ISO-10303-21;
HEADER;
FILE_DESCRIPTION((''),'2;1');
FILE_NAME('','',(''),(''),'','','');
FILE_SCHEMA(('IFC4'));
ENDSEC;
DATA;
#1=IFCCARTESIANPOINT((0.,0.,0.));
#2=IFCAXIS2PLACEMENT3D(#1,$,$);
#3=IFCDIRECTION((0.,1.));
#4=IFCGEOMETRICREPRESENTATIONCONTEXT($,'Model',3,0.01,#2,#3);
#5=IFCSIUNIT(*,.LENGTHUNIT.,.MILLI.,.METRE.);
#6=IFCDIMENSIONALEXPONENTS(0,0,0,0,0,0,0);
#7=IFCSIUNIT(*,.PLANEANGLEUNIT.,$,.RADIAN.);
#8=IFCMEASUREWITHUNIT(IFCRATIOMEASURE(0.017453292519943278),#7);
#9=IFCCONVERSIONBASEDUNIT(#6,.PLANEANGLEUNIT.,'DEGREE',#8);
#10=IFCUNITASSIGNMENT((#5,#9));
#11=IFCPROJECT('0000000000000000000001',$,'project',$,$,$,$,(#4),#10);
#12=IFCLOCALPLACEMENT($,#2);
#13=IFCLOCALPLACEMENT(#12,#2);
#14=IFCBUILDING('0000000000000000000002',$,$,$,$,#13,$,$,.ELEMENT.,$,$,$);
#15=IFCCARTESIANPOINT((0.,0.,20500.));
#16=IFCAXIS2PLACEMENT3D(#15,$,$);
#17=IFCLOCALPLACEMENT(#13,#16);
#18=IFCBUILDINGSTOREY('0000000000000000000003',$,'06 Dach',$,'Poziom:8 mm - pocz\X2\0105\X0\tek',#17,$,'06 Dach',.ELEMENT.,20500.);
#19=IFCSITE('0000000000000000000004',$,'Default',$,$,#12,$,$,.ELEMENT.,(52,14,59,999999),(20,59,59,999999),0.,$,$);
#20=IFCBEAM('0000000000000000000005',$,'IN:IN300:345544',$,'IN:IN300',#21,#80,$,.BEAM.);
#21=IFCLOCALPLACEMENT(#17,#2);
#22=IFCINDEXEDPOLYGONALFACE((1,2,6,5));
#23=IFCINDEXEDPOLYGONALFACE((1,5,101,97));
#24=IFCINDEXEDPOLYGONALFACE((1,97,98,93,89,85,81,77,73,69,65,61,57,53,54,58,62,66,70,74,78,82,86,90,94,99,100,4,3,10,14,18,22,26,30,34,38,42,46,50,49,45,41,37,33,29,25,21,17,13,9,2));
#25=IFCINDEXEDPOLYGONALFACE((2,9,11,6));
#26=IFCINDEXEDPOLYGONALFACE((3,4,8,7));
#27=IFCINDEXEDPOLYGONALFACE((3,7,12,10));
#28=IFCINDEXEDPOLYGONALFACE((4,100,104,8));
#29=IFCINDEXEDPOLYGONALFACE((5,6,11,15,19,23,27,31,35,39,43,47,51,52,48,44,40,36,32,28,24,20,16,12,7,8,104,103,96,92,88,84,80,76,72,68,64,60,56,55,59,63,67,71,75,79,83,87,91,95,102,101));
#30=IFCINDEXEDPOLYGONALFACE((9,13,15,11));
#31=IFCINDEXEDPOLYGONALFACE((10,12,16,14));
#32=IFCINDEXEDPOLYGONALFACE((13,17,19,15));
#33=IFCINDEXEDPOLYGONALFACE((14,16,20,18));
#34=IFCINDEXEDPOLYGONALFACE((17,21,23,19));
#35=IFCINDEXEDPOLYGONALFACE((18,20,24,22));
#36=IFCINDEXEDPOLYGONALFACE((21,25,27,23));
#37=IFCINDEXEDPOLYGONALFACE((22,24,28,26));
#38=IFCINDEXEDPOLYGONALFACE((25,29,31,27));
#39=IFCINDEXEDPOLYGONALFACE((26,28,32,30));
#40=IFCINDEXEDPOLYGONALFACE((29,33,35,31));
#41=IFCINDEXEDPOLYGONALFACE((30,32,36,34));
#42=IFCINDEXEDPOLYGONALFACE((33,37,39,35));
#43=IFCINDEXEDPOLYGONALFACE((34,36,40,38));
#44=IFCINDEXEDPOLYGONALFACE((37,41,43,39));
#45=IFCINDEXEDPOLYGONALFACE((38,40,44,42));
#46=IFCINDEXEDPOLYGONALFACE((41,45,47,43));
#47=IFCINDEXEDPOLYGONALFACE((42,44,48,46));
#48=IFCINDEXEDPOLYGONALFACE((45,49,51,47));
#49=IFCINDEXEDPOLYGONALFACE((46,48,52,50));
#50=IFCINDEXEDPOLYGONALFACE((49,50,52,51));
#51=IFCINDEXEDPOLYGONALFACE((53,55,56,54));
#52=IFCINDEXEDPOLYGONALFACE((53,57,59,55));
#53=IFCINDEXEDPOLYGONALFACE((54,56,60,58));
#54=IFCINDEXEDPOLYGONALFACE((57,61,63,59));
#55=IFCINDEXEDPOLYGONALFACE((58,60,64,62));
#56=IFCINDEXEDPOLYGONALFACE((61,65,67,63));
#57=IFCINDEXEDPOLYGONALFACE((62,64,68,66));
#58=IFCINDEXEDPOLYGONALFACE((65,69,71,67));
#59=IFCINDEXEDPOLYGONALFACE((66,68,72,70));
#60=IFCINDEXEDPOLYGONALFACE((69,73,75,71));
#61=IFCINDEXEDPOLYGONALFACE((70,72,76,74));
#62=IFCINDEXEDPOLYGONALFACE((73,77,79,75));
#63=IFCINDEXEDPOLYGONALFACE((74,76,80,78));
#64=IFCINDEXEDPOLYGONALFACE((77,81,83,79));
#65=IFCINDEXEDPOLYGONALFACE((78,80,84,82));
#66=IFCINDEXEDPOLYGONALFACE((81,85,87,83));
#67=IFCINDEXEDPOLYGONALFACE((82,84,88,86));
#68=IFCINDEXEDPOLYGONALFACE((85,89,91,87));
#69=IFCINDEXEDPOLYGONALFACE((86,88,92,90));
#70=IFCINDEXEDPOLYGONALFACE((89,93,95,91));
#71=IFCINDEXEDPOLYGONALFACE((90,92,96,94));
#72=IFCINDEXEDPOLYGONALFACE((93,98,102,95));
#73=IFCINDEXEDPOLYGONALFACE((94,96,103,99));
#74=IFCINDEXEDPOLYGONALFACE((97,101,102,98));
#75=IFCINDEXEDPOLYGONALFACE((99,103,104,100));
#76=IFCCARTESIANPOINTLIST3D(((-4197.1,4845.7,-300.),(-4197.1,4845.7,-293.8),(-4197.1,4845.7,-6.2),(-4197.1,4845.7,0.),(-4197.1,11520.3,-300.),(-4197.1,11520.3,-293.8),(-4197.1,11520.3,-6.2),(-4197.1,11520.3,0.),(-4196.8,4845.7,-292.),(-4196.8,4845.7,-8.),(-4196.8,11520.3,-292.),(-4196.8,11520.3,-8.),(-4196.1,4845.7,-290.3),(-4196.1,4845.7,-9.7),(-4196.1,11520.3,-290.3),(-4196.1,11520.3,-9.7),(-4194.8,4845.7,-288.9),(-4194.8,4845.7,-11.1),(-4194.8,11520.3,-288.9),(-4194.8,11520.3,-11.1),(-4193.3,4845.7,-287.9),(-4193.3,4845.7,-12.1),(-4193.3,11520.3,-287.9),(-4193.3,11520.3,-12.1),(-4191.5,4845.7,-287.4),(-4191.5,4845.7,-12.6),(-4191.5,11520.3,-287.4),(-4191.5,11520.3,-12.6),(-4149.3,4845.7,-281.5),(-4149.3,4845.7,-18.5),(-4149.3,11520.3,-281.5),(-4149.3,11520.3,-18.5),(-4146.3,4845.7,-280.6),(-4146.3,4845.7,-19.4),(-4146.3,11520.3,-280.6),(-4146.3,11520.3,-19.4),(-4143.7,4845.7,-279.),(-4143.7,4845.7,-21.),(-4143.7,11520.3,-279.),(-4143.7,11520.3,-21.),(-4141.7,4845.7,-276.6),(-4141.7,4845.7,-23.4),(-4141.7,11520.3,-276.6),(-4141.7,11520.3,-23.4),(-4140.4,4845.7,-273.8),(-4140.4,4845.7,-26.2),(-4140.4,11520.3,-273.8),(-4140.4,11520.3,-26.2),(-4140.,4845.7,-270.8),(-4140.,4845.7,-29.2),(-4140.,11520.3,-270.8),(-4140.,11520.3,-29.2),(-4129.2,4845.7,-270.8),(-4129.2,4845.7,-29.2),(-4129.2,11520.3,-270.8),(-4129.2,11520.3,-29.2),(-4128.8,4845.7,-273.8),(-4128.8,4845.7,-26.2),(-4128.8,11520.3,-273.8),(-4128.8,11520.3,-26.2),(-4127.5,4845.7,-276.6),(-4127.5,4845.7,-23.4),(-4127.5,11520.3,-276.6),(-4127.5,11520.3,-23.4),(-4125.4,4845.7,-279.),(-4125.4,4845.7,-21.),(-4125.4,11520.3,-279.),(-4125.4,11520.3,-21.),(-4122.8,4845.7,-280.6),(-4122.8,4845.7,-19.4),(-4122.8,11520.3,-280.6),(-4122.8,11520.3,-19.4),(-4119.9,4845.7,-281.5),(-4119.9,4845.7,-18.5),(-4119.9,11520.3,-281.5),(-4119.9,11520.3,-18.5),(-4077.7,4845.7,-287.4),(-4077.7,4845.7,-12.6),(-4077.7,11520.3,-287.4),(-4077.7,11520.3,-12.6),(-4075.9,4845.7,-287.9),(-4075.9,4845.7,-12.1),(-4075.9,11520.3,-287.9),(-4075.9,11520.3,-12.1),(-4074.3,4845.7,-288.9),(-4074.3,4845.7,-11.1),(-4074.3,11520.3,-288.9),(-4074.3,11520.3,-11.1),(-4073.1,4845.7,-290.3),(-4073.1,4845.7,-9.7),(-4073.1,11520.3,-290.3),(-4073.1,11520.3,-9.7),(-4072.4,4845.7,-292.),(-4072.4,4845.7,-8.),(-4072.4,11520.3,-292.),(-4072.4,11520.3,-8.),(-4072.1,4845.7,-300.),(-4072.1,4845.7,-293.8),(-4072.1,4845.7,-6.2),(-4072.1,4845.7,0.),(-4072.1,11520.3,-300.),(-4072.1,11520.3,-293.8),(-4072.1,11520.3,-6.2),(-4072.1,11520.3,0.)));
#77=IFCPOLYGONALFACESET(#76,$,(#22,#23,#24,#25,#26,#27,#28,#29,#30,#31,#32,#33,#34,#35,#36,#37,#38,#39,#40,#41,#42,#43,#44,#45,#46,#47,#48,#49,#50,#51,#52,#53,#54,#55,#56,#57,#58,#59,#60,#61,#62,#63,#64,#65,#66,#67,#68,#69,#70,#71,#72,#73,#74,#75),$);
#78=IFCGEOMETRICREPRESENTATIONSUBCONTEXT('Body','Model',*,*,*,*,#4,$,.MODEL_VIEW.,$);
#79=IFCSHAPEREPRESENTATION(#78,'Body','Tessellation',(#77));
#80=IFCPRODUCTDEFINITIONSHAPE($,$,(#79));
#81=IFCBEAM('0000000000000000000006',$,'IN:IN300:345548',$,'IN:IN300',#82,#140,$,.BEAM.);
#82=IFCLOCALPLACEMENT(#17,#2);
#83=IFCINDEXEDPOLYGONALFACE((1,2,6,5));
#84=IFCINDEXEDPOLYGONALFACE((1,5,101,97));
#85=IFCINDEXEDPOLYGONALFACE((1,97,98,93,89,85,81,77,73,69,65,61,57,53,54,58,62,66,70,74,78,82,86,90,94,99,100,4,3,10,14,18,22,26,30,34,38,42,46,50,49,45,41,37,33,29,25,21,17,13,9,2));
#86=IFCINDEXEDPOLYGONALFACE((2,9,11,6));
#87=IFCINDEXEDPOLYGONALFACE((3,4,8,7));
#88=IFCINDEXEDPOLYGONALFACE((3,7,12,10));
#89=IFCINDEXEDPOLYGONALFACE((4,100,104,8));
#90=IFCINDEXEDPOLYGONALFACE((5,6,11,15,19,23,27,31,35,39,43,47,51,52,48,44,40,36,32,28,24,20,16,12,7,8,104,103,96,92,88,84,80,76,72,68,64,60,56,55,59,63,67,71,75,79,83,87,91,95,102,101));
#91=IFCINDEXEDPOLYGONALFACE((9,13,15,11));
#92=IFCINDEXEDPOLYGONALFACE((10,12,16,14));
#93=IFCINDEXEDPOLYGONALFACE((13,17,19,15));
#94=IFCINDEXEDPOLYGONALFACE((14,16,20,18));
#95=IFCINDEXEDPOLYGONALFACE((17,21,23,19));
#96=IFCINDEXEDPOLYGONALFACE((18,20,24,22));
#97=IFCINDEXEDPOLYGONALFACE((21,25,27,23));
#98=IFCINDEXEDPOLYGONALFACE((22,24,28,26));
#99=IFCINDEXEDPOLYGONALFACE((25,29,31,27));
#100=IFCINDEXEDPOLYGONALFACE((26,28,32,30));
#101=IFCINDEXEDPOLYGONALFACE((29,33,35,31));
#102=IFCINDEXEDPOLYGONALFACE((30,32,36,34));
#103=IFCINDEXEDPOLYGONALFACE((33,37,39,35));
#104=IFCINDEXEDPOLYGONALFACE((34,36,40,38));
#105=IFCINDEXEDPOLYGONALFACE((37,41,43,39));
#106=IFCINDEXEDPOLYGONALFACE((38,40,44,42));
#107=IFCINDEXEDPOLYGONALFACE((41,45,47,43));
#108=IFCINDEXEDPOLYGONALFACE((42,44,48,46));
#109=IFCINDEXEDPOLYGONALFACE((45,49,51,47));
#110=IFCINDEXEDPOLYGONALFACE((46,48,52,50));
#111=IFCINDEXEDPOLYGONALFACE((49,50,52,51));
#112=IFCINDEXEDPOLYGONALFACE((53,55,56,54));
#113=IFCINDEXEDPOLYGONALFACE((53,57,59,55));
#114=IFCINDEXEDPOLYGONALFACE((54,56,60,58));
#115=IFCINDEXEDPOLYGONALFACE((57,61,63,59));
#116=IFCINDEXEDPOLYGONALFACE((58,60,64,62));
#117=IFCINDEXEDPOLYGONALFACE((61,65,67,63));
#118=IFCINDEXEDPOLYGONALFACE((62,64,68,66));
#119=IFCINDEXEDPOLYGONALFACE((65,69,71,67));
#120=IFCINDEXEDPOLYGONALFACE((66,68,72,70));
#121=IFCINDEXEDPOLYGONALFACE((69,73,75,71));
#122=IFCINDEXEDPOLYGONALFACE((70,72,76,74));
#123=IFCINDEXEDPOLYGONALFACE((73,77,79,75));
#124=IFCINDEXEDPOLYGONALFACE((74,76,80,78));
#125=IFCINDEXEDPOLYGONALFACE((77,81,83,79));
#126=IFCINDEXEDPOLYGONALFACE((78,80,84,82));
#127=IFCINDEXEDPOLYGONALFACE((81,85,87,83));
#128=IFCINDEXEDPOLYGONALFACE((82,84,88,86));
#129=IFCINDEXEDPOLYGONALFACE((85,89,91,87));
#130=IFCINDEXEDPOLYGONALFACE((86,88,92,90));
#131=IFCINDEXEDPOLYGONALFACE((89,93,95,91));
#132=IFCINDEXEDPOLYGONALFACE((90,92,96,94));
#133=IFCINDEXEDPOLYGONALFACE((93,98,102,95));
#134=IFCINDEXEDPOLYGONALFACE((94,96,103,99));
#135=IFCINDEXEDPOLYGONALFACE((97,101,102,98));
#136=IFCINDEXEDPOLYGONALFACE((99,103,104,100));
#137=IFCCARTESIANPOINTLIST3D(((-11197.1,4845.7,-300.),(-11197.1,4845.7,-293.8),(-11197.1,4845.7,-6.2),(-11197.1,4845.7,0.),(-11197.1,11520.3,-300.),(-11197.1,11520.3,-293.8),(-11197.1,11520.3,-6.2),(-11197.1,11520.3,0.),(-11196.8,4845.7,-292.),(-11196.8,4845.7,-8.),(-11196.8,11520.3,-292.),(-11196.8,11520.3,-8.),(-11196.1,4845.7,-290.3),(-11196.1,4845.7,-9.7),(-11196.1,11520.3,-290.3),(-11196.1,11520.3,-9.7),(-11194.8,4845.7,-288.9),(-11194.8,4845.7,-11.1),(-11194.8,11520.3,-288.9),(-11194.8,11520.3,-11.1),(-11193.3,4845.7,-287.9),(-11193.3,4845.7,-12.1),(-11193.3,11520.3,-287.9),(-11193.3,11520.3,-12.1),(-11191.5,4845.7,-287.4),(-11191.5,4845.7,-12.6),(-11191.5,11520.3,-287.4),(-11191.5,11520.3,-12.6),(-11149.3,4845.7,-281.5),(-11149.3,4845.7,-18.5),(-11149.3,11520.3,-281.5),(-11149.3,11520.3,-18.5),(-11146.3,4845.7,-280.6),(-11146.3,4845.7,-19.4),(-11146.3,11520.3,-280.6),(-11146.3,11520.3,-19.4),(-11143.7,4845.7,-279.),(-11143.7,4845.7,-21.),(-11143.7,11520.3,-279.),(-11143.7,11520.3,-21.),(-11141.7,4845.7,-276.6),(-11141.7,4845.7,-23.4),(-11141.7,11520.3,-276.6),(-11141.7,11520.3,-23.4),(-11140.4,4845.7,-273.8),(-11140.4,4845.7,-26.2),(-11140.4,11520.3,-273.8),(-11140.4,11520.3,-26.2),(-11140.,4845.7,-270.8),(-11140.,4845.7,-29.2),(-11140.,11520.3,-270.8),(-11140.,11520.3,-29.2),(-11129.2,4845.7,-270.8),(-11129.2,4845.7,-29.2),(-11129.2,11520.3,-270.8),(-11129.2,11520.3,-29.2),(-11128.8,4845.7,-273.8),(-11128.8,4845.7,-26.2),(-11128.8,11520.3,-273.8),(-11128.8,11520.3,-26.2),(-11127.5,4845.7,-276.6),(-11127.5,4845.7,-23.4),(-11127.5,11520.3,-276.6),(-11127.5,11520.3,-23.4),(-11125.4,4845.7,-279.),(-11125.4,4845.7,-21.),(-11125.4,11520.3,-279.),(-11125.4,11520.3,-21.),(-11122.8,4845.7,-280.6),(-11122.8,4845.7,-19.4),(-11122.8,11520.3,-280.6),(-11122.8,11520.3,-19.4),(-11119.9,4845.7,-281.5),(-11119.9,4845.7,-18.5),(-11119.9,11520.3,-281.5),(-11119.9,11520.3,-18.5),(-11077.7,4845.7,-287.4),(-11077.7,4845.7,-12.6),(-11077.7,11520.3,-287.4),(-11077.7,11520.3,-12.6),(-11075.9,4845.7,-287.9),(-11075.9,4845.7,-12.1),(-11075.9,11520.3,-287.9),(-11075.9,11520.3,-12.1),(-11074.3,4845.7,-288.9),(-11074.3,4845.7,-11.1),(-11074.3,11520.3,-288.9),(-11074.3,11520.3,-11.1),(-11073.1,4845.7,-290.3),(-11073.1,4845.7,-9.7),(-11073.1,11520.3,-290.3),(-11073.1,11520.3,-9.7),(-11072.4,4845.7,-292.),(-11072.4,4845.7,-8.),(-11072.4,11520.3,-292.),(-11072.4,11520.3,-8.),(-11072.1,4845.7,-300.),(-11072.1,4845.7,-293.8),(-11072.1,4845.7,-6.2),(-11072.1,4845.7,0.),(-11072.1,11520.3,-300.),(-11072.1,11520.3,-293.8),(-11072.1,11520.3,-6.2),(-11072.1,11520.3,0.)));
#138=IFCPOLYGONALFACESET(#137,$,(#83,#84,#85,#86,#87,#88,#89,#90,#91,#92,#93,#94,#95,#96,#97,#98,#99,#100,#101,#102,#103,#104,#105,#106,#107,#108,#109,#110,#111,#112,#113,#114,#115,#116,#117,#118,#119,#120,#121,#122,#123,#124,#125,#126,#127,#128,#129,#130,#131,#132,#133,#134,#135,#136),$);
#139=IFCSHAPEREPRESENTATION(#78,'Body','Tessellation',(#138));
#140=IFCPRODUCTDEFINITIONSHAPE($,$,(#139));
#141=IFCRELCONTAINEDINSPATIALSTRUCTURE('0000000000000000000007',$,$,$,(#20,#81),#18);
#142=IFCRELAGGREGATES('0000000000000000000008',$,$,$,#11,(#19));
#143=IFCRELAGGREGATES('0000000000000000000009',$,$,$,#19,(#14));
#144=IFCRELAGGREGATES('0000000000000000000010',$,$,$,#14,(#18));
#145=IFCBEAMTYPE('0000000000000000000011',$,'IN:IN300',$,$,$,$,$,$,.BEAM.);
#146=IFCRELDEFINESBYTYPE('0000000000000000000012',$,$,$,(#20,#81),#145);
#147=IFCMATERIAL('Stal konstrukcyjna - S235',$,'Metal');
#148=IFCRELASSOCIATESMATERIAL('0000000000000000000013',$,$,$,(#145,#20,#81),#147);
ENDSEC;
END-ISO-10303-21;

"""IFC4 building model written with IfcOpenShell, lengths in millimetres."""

from ifc_helpers import new_model, entity, si_unit, converted_unit, direction, frame, origin, place, context, subcontext, project, spatial, line, arc, indexed_curve, outline, extrude, source, transform, mapped, material, type_object, type_shapes, element, save


model = new_model("IFC4")

# Units and contexts
model_context = context("Model", 3, precision=0.01, world=origin(), true_north=direction((0.0, 1.0)))
body_context = subcontext(model_context, "Body", "Model", "MODEL_VIEW")
ifc_project = project(units=[si_unit("LENGTHUNIT", "METRE", prefix="MILLI"), converted_unit("PLANEANGLEUNIT", "DEGREE", entity("IfcRatioMeasure", 0.017453292519943278), si_unit("PLANEANGLEUNIT", "RADIAN"), dimensions=[0, 0, 0, 0, 0, 0, 0])], contexts=[model_context])

# Site, building, storey
site_placement = place(None, origin())
site = spatial("IfcSite", under=ifc_project, at=site_placement, Name="Default", CompositionType="ELEMENT", RefLatitude=(52, 14, 59, 999999), RefLongitude=(20, 59, 59, 999999), RefElevation=0.0)
building_placement = place(site_placement, origin())
building = spatial("IfcBuilding", under=site, at=building_placement, CompositionType="ELEMENT")
storey_placement = place(building_placement, frame((0.0, 0.0, 20500.0)))
storey = spatial("IfcBuildingStorey", under=building, at=storey_placement, Name="06 Dach", ObjectType="Poziom:8 mm - początek", LongName="06 Dach", CompositionType="ELEMENT", Elevation=20500.0)

# Beams
ifc_material = material(Name="Stal konstrukcyjna - S235", Category="Metal")
beam_type_1 = type_object("IfcBeamType", Name="IN:IN300", PredefinedType="BEAM", material=ifc_material)
shared_shape_1 = source(origin(), body_context, "Body", "SweptSolid", [
    extrude(outline(indexed_curve([(143.8, -62.5), (150.0, -62.5), (150.0, 62.5), (143.8, 62.5), (139.6, 60.9), (137.4, 56.9), (131.5, 14.7), (127.9, 8.1), (120.8, 5.4), (-120.8, 5.4), (-127.9, 8.1), (-131.5, 14.7), (-137.4, 56.9), (-139.6, 60.9), (-143.8, 62.5), (-150.0, 62.5), (-150.0, -62.5), (-143.8, -62.5), (-139.6, -60.9), (-137.4, -56.9), (-131.5, -14.7), (-127.9, -8.1), (-120.8, -5.4), (120.8, -5.4), (127.9, -8.1), (131.5, -14.7), (137.4, -56.9), (139.6, -60.9)], segments=[line(1, 2, 3, 4), arc(4, 5, 6), line(6, 7), arc(7, 8, 9), line(9, 10), arc(10, 11, 12), line(12, 13), arc(13, 14, 15), line(15, 16, 17, 18), arc(18, 19, 20), line(20, 21), arc(21, 22, 23), line(23, 24), arc(24, 25, 26), line(26, 27), arc(27, 28, 1)], self_intersect=False)), frame((-3337.3, 0.0, 0.0), z_axis=(1.0, 0.0, 0.0), x_axis=(0.0, 0.0, -1.0)), (0.0, 0.0, 1.0), 6674.6),
])
type_shapes(beam_type_1, [shared_shape_1])
for number, where, z_axis, x_axis, name in (
    (1, (-4134.6, 8183.0, -150.0), (0.0, 0.0, 1.0), (0.0, -1.0, 0.0), "IN:IN300:345544"),
    (2, (-11134.6, 8183.0, -150.0), (0.0, 0.0, 1.0), (0.0, -1.0, 0.0), "IN:IN300:345548"),
):
    element("IfcBeam", number, at=place(storey_placement, frame(where, z_axis=z_axis, x_axis=x_axis)), inside=storey, type_object=beam_type_1, material=ifc_material, Name=name, ObjectType="IN:IN300", PredefinedType="BEAM", context=body_context, shape_type="MappedRepresentation", body=[
        mapped(shared_shape_1, transform((0.0, 0.0, 0.0), scale=1.0)),
    ])

save(model, "model.ifc")
